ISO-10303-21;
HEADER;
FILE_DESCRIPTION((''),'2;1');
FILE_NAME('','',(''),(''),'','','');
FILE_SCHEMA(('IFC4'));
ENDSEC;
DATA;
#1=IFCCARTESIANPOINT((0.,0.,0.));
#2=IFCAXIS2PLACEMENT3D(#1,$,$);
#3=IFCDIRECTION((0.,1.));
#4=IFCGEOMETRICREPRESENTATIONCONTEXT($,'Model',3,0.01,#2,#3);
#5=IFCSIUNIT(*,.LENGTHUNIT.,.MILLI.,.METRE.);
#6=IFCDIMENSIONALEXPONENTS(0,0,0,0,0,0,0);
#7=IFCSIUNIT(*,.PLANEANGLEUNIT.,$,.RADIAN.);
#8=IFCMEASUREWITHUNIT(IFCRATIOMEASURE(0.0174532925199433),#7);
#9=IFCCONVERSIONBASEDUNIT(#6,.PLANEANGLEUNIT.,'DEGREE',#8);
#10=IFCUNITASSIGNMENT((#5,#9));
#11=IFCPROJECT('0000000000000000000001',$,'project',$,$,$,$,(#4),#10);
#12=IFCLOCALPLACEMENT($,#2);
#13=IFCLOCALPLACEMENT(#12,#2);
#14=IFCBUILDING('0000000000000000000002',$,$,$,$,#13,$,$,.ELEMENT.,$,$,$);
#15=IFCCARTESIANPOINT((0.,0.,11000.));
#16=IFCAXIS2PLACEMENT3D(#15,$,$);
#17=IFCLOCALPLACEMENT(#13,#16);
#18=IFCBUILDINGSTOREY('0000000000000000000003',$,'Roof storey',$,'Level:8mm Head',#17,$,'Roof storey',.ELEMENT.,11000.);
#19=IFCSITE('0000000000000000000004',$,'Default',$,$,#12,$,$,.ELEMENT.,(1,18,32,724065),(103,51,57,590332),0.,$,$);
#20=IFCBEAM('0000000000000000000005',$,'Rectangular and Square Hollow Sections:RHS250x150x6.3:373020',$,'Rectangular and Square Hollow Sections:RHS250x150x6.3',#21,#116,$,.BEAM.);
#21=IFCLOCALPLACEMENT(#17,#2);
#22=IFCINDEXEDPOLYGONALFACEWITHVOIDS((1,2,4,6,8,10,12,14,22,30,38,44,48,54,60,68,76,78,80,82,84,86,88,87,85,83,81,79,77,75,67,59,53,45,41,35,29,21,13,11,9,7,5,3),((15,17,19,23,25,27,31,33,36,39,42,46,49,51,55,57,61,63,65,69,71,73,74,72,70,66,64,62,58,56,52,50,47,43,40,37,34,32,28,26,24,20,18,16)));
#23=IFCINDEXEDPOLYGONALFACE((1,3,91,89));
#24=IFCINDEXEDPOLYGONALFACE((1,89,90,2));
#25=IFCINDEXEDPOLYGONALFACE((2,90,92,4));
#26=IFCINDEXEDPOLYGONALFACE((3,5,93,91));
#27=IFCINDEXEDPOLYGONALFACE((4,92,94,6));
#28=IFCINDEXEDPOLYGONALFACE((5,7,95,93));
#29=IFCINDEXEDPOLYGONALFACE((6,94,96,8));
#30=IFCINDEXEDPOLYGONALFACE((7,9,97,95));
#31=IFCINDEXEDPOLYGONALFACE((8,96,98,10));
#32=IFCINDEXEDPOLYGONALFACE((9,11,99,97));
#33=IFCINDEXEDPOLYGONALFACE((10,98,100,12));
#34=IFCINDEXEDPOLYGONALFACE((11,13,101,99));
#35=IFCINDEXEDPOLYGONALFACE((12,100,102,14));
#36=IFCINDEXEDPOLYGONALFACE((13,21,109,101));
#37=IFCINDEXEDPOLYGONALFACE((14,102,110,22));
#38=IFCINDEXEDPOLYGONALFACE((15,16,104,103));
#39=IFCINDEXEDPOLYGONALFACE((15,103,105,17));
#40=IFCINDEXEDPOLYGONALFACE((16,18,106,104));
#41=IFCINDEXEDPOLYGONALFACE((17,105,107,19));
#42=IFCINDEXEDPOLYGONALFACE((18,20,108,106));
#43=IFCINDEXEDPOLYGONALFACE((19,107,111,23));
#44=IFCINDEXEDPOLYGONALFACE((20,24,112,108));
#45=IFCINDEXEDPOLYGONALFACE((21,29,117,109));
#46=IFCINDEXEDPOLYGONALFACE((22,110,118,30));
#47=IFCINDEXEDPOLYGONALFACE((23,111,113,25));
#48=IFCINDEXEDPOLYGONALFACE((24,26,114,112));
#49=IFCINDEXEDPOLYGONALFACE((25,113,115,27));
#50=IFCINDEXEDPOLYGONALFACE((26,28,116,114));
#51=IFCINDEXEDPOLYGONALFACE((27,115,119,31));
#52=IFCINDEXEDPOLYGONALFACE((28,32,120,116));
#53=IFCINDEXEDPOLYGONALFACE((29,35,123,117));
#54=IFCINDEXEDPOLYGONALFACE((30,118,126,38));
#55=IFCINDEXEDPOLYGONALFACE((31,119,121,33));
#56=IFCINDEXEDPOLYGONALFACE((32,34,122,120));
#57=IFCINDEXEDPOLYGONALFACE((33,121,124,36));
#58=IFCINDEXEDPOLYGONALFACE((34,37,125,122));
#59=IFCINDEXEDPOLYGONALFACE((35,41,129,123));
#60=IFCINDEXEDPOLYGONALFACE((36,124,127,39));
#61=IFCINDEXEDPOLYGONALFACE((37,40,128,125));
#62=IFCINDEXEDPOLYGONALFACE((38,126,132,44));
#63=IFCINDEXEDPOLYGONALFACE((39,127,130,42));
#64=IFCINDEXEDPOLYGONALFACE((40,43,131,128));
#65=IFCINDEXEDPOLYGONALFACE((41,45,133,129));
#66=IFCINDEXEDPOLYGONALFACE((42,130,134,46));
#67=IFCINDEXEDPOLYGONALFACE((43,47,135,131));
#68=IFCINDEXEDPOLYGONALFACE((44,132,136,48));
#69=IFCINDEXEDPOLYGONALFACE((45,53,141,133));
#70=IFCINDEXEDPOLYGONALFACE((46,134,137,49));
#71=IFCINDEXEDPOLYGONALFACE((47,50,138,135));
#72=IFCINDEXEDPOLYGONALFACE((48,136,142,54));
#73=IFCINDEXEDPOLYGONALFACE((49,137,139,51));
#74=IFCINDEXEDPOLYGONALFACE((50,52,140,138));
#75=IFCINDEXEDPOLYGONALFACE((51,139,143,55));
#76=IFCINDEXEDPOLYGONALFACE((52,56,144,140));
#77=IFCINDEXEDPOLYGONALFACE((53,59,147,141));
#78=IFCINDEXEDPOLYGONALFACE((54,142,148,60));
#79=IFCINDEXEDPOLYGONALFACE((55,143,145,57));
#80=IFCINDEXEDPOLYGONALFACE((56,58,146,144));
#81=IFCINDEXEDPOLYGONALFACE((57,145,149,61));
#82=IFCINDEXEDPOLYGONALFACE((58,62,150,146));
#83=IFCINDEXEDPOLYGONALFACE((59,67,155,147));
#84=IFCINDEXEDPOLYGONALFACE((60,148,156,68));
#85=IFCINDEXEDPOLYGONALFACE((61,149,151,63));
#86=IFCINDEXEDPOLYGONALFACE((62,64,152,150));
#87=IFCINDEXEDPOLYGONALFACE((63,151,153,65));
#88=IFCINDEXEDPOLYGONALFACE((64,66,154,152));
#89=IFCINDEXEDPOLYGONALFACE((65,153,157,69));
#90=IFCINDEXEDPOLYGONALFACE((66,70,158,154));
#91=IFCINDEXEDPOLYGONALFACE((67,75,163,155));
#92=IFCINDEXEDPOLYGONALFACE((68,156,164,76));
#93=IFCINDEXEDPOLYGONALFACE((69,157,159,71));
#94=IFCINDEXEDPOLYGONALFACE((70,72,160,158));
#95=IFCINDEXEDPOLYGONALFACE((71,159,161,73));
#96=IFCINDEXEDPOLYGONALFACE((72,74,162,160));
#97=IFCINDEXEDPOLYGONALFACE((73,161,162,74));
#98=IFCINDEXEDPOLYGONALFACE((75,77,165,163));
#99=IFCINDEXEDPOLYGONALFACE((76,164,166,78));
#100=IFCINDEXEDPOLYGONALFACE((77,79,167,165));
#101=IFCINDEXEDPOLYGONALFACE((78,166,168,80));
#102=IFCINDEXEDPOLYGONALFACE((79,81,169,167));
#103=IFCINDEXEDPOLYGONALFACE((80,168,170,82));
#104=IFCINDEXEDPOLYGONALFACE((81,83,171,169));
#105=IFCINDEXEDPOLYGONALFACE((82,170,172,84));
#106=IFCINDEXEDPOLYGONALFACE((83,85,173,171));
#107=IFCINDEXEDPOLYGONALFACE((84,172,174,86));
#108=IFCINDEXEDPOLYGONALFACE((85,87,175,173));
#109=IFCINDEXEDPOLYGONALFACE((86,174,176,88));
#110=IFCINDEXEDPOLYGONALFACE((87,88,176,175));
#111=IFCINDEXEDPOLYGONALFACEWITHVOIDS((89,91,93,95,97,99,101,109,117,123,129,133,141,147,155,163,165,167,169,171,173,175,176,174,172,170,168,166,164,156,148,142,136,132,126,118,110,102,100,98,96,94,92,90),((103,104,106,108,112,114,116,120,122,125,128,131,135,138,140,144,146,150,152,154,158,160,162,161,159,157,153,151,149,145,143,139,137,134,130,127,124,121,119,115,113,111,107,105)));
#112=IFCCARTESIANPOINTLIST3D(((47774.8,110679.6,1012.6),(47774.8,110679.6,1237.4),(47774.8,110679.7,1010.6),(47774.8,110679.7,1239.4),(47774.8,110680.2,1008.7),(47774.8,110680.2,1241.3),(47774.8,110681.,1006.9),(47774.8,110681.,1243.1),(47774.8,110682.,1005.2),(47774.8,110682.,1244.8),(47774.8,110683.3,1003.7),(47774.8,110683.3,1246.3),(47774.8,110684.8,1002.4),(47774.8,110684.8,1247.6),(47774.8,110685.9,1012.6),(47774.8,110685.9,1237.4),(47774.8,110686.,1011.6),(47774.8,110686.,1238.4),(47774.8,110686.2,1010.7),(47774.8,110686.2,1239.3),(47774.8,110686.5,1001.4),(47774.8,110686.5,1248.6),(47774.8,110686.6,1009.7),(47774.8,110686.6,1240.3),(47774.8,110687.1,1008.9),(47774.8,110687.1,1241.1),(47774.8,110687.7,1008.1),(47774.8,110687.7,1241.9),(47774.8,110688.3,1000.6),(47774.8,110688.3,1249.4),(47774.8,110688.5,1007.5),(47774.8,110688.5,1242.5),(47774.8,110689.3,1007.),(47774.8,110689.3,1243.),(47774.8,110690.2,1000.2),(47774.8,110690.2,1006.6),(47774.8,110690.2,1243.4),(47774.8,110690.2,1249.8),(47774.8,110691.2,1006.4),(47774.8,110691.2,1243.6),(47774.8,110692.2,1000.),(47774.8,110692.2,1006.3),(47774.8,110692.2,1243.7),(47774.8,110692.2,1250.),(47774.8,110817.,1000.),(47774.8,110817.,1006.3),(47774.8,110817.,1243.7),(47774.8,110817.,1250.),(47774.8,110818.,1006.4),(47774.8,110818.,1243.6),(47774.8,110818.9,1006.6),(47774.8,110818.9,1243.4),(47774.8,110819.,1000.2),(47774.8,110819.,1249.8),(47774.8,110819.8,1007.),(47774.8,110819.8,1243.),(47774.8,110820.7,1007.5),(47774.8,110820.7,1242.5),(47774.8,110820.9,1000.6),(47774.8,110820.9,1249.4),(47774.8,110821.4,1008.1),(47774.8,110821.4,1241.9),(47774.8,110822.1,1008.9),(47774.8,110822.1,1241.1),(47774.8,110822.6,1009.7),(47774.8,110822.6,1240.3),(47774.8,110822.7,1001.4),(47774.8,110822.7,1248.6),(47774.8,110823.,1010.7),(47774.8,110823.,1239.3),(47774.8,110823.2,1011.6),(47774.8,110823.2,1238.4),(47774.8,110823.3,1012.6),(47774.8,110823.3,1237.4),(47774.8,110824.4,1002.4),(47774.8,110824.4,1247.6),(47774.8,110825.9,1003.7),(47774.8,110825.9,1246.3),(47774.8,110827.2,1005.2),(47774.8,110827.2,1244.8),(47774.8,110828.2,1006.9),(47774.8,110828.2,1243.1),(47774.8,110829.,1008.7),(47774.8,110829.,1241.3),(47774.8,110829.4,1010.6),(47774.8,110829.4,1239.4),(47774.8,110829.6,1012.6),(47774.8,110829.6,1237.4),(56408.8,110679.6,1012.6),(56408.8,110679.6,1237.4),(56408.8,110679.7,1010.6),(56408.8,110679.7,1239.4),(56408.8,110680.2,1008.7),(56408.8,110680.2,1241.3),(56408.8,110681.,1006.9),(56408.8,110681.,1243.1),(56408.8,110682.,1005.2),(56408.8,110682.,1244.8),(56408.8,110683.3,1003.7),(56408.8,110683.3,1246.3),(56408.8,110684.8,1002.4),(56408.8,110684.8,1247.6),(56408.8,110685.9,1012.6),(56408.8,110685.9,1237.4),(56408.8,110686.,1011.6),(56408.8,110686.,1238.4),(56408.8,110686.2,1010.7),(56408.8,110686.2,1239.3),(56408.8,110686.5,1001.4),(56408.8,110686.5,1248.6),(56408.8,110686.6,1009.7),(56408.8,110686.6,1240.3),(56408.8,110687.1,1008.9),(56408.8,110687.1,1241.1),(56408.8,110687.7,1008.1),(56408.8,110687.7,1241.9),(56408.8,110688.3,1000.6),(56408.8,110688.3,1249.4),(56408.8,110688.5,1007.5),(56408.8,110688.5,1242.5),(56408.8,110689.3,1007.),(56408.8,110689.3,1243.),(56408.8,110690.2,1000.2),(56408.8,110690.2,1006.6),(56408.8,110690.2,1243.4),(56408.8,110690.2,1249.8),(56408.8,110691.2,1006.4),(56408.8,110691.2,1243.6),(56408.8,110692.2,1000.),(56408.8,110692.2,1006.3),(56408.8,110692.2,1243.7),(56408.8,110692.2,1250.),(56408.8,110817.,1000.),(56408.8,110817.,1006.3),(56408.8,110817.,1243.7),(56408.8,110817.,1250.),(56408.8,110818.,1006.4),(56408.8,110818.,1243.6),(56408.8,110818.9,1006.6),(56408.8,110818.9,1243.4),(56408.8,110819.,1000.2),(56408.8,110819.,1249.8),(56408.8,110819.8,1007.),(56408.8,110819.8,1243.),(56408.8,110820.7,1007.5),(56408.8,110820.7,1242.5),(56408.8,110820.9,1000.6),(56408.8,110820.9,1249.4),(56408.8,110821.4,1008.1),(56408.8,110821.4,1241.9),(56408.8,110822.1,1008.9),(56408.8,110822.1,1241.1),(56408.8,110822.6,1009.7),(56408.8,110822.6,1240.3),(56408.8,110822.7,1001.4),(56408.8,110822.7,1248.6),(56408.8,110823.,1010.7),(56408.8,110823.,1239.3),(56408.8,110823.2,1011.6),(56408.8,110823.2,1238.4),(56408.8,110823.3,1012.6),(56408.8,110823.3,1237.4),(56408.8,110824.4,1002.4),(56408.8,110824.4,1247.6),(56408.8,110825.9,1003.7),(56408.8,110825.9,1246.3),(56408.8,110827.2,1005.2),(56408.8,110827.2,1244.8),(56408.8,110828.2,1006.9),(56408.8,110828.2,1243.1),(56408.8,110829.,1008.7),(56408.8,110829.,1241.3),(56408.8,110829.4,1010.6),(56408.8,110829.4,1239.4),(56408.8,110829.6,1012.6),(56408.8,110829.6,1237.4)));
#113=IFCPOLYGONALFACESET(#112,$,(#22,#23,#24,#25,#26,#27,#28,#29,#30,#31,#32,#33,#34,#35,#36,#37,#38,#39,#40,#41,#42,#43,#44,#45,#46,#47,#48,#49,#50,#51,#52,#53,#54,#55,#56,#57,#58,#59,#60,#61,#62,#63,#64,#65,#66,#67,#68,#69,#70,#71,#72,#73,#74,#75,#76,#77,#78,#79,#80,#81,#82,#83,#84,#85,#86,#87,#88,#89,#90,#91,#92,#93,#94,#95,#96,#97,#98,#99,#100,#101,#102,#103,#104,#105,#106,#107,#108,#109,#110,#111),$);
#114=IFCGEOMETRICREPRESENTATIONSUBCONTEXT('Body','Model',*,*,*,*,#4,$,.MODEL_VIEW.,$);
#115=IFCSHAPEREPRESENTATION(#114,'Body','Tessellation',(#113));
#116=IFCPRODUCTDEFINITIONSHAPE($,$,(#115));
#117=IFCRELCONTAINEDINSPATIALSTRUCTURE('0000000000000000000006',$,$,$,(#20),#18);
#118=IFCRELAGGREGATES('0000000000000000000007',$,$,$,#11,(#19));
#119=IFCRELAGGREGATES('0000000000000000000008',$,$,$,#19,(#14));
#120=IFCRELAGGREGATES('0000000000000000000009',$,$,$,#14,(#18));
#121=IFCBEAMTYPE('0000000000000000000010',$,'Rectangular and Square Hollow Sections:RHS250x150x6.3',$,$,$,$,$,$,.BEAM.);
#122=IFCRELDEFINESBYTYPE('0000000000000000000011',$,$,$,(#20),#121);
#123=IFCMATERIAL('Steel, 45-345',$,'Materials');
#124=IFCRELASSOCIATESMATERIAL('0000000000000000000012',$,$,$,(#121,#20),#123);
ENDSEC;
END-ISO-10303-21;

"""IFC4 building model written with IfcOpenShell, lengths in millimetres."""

from ifc_helpers import new_model, entity, si_unit, converted_unit, direction, frame, origin, place, context, subcontext, project, spatial, indexed_curve, outline, extrude, source, transform, mapped, material, type_object, type_shapes, element, save


model = new_model("IFC4")

# Units and contexts
model_context = context("Model", 3, precision=0.01, world=origin(), true_north=direction((0.0, 1.0)))
body_context = subcontext(model_context, "Body", "Model", "MODEL_VIEW")
ifc_project = project(units=[si_unit("LENGTHUNIT", "METRE", prefix="MILLI"), converted_unit("PLANEANGLEUNIT", "DEGREE", entity("IfcRatioMeasure", 0.0174532925199433), si_unit("PLANEANGLEUNIT", "RADIAN"), dimensions=[0, 0, 0, 0, 0, 0, 0])], contexts=[model_context])

# Site, building, storey
site_placement = place(None, origin())
site = spatial("IfcSite", under=ifc_project, at=site_placement, Name="Default", CompositionType="ELEMENT", RefLatitude=(1, 18, 32, 724065), RefLongitude=(103, 51, 57, 590332), RefElevation=0.0)
building_placement = place(site_placement, origin())
building = spatial("IfcBuilding", under=site, at=building_placement, CompositionType="ELEMENT")
storey_placement = place(building_placement, frame((0.0, 0.0, 11000.0)))
storey = spatial("IfcBuildingStorey", under=building, at=storey_placement, Name="Roof storey", ObjectType="Level:8mm Head", LongName="Roof storey", CompositionType="ELEMENT", Elevation=11000.0)

# Shared definitions
ifc_material = material(Name="Steel, 45-345", Category="Materials")

# Beam
beam_type_1 = type_object("IfcBeamType", Name="Rectangular and Square Hollow Sections:RHS250x150x6.3", PredefinedType="BEAM", material=ifc_material)
shared_shape_1 = source(origin(), body_context, "Body", "SweptSolid", [
    extrude(outline(indexed_curve([(-75.0, -112.4), (-74.8, -114.4), (-74.4, -116.3), (-73.6, -118.1), (-72.6, -119.8), (-71.3, -121.3), (-69.8, -122.6), (-68.1, -123.6), (-66.3, -124.4), (-64.4, -124.8), (-62.4, -125.0), (62.4, -125.0), (64.4, -124.8), (66.3, -124.4), (68.1, -123.6), (69.8, -122.6), (71.3, -121.3), (72.6, -119.8), (73.6, -118.1), (74.4, -116.3), (74.8, -114.4), (75.0, -112.4), (75.0, 112.4), (74.8, 114.4), (74.4, 116.3), (73.6, 118.1), (72.6, 119.8), (71.3, 121.3), (69.8, 122.6), (68.1, 123.6), (66.3, 124.4), (64.4, 124.8), (62.4, 125.0), (-62.4, 125.0), (-64.4, 124.8), (-66.3, 124.4), (-68.1, 123.6), (-69.8, 122.6), (-71.3, 121.3), (-72.6, 119.8), (-73.6, 118.1), (-74.4, 116.3), (-74.8, 114.4), (-75.0, 112.4), (-75.0, -112.4)], self_intersect=False), holes=[indexed_curve([(62.4, -118.7), (-62.4, -118.7), (-63.4, -118.6), (-64.3, -118.4), (-65.3, -118.0), (-66.1, -117.5), (-66.9, -116.9), (-67.5, -116.1), (-68.0, -115.3), (-68.4, -114.3), (-68.6, -113.4), (-68.7, -112.4), (-68.7, 112.4), (-68.6, 113.4), (-68.4, 114.3), (-68.0, 115.3), (-67.5, 116.1), (-66.9, 116.9), (-66.1, 117.5), (-65.3, 118.0), (-64.3, 118.4), (-63.4, 118.6), (-62.4, 118.7), (62.4, 118.7), (63.4, 118.6), (64.3, 118.4), (65.3, 118.0), (66.1, 117.5), (66.9, 116.9), (67.5, 116.1), (68.0, 115.3), (68.4, 114.3), (68.6, 113.4), (68.7, 112.4), (68.7, -112.4), (68.6, -113.4), (68.4, -114.3), (68.0, -115.3), (67.5, -116.1), (66.9, -116.9), (66.1, -117.5), (65.3, -118.0), (64.3, -118.4), (63.4, -118.6), (62.4, -118.7)], self_intersect=False)]), frame((-4317.0, 0.0, 0.0), z_axis=(1.0, 0.0, 0.0), x_axis=(0.0, -1.0, 0.0)), (0.0, 0.0, 1.0), 8634.0),
])
type_shapes(beam_type_1, [shared_shape_1])
beam_1_placement = place(storey_placement, frame((52091.8, 110754.6, 1125.0)))
element("IfcBeam", 1, at=beam_1_placement, inside=storey, type_object=beam_type_1, material=ifc_material, Name="Rectangular and Square Hollow Sections:RHS250x150x6.3:373020", ObjectType="Rectangular and Square Hollow Sections:RHS250x150x6.3", PredefinedType="BEAM", context=body_context, shape_type="MappedRepresentation", body=[
    mapped(shared_shape_1, transform((0.0, 0.0, 0.0), scale=1.0)),
])

save(model, "model.ifc")
